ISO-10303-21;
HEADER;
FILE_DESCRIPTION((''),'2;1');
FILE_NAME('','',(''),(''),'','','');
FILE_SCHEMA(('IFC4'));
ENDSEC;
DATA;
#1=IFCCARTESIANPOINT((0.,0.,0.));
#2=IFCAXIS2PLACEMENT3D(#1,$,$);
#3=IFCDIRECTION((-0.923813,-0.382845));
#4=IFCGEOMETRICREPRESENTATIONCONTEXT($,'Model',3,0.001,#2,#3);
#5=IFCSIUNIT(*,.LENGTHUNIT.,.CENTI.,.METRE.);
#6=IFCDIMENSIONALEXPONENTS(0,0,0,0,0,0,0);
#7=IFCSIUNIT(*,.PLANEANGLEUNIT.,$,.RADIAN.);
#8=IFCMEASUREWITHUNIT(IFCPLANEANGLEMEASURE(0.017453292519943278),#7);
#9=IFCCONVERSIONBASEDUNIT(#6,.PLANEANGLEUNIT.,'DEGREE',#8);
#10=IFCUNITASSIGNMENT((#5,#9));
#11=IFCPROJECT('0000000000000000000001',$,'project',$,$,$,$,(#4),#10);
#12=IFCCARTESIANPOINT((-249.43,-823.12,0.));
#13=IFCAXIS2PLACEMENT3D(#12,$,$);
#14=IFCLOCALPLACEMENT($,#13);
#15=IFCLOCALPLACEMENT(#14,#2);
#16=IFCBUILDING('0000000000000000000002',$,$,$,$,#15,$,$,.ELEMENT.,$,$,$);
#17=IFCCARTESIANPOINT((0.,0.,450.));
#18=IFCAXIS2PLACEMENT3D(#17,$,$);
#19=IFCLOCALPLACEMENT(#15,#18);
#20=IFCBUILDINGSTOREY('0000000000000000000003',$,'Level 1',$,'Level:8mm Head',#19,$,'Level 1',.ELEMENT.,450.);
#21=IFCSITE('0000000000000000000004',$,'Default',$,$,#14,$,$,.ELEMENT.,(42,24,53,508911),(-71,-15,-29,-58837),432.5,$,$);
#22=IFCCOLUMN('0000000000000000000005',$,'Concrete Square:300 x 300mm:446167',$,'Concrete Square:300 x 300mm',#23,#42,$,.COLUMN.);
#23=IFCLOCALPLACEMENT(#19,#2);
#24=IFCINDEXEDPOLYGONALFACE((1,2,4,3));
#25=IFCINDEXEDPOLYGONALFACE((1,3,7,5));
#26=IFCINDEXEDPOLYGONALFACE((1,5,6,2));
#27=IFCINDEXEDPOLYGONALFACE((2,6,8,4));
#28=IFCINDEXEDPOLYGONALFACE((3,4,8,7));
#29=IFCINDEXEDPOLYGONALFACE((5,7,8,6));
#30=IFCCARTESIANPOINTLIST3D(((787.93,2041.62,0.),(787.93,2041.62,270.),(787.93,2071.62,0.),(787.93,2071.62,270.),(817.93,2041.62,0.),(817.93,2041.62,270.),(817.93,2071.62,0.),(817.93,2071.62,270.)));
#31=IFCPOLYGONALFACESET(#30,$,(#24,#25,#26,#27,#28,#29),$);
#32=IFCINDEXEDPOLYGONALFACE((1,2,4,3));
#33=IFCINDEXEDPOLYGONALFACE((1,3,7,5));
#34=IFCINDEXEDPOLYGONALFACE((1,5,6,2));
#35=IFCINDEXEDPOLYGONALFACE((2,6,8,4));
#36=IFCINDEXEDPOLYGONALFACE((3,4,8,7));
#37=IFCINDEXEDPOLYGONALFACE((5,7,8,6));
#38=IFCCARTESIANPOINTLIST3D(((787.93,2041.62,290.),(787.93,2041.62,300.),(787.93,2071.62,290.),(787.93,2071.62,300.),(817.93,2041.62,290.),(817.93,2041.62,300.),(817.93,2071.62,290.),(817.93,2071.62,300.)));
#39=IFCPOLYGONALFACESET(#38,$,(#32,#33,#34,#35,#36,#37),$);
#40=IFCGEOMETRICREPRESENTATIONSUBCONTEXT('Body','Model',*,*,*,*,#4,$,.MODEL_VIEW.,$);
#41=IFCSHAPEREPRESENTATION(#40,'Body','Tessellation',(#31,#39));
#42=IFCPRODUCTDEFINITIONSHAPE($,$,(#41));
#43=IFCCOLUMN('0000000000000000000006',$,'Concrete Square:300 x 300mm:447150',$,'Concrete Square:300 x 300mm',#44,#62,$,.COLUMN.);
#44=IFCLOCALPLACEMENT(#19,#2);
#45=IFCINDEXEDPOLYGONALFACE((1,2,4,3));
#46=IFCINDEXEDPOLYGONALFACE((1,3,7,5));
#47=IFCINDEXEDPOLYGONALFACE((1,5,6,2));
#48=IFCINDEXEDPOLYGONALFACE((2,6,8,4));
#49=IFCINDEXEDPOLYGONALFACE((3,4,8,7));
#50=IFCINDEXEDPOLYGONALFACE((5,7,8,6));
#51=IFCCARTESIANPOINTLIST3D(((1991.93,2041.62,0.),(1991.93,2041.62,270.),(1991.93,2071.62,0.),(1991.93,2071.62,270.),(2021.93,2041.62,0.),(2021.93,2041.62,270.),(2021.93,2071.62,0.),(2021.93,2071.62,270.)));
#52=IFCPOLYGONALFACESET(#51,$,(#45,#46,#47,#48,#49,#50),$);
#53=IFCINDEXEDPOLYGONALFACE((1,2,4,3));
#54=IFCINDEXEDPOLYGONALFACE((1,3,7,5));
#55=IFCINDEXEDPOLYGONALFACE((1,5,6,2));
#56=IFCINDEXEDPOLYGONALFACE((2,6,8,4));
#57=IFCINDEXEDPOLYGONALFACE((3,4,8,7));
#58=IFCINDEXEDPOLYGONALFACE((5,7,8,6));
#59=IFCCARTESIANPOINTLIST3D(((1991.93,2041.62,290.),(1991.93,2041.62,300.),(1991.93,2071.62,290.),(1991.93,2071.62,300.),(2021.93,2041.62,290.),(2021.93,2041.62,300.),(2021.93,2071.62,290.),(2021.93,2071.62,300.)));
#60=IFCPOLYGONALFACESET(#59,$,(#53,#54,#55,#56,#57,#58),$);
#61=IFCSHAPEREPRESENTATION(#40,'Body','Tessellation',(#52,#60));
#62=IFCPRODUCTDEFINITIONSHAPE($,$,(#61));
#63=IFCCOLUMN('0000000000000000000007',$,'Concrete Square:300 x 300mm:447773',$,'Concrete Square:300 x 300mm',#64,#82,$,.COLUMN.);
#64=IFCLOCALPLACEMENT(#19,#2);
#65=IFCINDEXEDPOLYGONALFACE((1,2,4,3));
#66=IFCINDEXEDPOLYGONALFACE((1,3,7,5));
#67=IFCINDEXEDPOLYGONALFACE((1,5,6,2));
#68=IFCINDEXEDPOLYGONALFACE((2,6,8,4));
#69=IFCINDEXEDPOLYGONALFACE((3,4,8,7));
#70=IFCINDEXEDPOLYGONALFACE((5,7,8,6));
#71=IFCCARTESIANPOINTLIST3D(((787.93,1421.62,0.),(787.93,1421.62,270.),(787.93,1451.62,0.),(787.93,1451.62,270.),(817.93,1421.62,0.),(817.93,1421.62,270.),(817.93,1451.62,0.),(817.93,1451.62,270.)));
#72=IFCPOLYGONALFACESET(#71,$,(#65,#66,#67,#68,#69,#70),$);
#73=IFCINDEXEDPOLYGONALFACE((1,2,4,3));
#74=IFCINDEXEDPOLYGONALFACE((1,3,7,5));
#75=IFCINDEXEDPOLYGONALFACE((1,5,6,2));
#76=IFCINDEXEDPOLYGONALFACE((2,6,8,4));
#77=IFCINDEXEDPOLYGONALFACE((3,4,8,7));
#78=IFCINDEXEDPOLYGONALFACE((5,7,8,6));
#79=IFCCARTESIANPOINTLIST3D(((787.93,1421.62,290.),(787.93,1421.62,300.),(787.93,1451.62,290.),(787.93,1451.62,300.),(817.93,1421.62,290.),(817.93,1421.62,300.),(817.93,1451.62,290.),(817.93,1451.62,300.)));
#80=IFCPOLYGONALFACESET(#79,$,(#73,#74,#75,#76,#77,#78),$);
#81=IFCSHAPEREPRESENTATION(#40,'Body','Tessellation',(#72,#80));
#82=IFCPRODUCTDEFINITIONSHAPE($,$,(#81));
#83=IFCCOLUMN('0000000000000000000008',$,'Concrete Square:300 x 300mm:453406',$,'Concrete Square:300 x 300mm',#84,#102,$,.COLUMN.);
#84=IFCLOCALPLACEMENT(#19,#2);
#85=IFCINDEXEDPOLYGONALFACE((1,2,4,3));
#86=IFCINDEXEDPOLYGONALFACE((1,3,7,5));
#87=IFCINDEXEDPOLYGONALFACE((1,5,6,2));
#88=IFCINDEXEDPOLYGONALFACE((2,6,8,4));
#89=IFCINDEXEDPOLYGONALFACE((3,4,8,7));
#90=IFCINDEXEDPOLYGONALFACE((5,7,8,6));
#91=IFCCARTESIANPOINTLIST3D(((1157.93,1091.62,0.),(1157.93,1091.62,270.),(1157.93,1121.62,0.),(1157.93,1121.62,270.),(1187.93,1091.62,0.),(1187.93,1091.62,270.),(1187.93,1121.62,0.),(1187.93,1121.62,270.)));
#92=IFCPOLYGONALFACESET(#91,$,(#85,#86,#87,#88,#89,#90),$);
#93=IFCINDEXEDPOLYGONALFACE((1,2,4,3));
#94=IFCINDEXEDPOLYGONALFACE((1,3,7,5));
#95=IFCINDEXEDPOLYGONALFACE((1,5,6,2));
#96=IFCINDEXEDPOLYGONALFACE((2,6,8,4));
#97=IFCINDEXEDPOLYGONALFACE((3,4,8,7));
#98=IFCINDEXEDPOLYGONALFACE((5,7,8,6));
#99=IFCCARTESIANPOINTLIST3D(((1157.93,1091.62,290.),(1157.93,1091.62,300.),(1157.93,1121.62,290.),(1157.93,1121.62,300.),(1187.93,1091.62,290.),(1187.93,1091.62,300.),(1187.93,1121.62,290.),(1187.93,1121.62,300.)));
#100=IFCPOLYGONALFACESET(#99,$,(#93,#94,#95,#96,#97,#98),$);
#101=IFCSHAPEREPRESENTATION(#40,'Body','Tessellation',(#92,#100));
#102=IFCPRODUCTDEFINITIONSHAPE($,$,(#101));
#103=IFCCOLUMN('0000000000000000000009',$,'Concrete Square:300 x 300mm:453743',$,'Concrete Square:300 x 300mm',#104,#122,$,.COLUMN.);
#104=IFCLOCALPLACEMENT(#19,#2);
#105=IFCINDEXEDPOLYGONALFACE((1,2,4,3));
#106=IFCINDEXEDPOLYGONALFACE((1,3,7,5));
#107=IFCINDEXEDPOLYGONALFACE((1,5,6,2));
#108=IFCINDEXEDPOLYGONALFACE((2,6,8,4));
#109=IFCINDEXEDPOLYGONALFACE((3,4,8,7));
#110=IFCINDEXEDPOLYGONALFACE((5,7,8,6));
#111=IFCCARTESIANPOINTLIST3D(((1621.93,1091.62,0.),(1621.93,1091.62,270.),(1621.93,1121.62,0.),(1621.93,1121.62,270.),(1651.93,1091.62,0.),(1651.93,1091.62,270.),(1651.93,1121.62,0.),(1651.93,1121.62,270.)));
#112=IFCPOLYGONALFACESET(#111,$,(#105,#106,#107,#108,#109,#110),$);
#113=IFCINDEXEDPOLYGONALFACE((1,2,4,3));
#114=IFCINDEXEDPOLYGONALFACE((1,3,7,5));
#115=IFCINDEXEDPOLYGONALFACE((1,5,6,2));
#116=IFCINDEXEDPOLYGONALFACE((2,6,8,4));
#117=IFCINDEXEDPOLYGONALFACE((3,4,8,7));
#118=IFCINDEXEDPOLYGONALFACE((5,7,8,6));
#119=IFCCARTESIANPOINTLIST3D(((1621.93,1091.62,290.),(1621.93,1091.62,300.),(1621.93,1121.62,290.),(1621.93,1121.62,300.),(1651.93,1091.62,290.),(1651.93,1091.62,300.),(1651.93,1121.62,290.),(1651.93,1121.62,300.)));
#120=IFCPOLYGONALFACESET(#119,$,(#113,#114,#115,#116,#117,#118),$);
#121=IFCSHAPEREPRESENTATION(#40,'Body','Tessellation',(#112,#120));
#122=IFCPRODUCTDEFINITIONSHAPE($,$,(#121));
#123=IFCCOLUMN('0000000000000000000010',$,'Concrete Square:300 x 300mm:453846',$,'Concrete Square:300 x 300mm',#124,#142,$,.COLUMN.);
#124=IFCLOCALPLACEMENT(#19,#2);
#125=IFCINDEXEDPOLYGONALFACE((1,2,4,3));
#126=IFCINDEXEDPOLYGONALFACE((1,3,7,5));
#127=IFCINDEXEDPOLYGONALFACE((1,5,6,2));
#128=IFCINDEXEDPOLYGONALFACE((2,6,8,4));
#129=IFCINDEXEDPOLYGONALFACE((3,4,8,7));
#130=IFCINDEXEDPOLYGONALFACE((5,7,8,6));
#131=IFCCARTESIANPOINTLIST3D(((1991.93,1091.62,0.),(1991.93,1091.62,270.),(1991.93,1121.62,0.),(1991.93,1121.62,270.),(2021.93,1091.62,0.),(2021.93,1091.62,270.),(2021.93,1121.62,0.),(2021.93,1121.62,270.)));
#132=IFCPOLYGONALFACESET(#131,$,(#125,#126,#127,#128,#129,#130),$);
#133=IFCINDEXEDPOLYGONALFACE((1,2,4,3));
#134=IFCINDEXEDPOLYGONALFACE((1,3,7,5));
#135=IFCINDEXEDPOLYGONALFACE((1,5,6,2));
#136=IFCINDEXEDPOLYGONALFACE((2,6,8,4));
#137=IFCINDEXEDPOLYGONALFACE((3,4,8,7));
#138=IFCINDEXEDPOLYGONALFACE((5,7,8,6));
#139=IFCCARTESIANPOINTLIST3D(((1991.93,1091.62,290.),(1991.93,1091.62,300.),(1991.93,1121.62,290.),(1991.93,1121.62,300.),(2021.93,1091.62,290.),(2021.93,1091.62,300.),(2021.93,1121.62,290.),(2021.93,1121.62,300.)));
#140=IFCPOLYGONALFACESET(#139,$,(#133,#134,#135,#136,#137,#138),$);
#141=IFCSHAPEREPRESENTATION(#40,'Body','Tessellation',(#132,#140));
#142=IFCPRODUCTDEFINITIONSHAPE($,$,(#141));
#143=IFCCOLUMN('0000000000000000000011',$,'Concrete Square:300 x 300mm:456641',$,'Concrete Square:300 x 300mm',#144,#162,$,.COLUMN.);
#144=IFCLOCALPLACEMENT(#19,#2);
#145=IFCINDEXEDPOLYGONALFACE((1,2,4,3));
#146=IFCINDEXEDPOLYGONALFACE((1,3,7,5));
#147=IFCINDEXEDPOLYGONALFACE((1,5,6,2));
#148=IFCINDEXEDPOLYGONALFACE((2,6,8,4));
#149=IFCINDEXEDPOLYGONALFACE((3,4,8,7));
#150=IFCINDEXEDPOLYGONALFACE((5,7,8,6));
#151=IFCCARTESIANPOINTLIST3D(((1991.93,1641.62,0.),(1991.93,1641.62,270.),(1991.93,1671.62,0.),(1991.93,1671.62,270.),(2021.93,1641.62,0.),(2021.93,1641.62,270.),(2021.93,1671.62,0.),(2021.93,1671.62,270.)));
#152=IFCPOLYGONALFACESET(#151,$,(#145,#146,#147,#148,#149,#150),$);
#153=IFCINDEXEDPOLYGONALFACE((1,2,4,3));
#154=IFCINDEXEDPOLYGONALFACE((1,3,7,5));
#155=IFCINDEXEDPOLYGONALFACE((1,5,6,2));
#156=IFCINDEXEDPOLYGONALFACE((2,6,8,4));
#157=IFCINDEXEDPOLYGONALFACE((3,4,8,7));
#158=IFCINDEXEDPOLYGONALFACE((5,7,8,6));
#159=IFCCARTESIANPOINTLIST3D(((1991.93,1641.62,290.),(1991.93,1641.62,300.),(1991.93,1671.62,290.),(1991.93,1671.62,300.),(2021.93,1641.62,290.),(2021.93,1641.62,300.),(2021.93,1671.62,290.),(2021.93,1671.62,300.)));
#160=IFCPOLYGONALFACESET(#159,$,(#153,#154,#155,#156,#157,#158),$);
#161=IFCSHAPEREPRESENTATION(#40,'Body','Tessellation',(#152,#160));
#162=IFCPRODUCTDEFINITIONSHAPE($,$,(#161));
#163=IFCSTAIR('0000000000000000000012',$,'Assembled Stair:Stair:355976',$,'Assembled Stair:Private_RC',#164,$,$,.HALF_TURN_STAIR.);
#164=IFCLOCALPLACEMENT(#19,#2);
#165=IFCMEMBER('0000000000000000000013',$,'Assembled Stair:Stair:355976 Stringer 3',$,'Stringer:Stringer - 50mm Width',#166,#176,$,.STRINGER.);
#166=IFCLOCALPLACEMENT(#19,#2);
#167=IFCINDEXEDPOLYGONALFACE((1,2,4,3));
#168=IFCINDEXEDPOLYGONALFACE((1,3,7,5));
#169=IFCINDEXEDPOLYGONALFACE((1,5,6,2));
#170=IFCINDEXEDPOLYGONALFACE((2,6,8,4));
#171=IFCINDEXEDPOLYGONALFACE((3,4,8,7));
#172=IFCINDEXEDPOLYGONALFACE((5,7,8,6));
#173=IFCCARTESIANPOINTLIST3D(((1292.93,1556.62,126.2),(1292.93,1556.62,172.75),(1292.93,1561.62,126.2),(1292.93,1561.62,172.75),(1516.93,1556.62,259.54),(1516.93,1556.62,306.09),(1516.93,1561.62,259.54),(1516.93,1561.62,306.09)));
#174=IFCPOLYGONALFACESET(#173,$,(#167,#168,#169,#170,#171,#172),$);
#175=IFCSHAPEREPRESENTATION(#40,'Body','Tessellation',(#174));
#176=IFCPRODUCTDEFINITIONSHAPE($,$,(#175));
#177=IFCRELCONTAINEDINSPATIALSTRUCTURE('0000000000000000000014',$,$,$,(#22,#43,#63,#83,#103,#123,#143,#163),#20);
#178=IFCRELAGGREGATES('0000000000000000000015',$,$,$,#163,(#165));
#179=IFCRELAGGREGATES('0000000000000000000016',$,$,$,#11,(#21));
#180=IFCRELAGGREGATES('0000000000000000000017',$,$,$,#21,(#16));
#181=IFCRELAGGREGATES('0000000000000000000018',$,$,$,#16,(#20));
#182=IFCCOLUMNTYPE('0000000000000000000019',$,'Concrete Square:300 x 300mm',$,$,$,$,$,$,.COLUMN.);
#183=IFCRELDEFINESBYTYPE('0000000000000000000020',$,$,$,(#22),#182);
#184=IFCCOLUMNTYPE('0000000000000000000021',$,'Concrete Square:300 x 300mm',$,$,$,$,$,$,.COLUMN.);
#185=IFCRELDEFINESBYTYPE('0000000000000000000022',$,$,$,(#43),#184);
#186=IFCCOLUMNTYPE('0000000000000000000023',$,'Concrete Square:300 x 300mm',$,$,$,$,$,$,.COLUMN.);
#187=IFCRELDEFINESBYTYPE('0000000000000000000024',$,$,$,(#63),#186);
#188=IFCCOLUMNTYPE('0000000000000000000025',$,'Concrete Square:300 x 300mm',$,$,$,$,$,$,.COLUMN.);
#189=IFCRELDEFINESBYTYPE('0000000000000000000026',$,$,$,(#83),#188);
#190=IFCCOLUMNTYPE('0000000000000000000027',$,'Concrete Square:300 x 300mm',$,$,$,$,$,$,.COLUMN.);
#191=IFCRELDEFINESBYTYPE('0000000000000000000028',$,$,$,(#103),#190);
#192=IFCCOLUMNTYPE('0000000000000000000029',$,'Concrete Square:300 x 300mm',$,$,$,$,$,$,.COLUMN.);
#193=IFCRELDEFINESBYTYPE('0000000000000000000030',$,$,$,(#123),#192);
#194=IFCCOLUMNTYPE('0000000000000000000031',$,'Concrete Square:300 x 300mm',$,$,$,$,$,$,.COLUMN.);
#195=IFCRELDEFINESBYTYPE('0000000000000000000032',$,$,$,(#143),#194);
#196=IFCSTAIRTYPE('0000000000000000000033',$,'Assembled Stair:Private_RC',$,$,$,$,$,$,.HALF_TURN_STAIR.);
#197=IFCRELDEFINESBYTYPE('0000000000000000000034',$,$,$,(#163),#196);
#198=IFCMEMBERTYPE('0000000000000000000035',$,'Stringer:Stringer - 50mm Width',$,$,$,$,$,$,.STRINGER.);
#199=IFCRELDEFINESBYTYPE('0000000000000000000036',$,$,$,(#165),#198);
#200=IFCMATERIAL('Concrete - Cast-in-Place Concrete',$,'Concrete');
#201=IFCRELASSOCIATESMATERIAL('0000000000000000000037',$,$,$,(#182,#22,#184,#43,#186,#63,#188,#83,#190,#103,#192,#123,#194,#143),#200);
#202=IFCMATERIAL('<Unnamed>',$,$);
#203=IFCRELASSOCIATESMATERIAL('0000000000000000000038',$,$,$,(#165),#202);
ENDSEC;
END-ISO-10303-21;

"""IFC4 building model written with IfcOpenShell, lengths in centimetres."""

from ifc_helpers import new_model, entity, si_unit, converted_unit, direction, frame, origin, place, context, subcontext, project, spatial, indexed_curve, outline, extrude, source, transform, mapped, material, type_object, type_shapes, element, aggregate, save


model = new_model("IFC4")

# Units and contexts
model_context = context("Model", 3, precision=0.001, world=origin(), true_north=direction((-0.923813, -0.382845)))
body_context = subcontext(model_context, "Body", "Model", "MODEL_VIEW")
ifc_project = project(units=[si_unit("LENGTHUNIT", "METRE", prefix="CENTI"), converted_unit("PLANEANGLEUNIT", "DEGREE", entity("IfcPlaneAngleMeasure", 0.017453292519943278), si_unit("PLANEANGLEUNIT", "RADIAN"), dimensions=[0, 0, 0, 0, 0, 0, 0])], contexts=[model_context])

# Site, building, storey
site_placement = place(None, frame((-249.43, -823.12, 0.0)))
site = spatial("IfcSite", under=ifc_project, at=site_placement, Name="Default", CompositionType="ELEMENT", RefLatitude=(42, 24, 53, 508911), RefLongitude=(-71, -15, -29, -58837), RefElevation=432.5)
building_placement = place(site_placement, origin())
building = spatial("IfcBuilding", under=site, at=building_placement, CompositionType="ELEMENT")
storey_placement = place(building_placement, frame((0.0, 0.0, 450.0)))
storey = spatial("IfcBuildingStorey", under=building, at=storey_placement, Name="Level 1", ObjectType="Level:8mm Head", LongName="Level 1", CompositionType="ELEMENT", Elevation=450.0)

# Columns
ifc_material_1 = material(Name="Concrete - Cast-in-Place Concrete", Category="Concrete")
column_type_1 = type_object("IfcColumnType", Name="Concrete Square:300 x 300mm", PredefinedType="COLUMN", material=ifc_material_1)
shared_shape_1 = source(origin(), body_context, "Body", "SweptSolid", [
    extrude(outline(indexed_curve([(-15.0, -15.0), (15.0, -15.0), (15.0, 15.0), (-15.0, 15.0), (-15.0, -15.0)], self_intersect=False)), frame((802.93, 2056.62, 450.0), z_axis=(0.0, 0.0, 1.0), x_axis=(-1.0, 0.0, 0.0)), (0.0, 0.0, 1.0), 270.0),
    extrude(outline(indexed_curve([(-15.0, -15.0), (15.0, -15.0), (15.0, 15.0), (-15.0, 15.0), (-15.0, -15.0)], self_intersect=False)), frame((802.93, 2056.62, 740.0), z_axis=(0.0, 0.0, 1.0), x_axis=(-1.0, 0.0, 0.0)), (0.0, 0.0, 1.0), 10.0),
])
type_shapes(column_type_1, [shared_shape_1])
column_1_placement = place(storey_placement, frame((0.0, 0.0, -450.0)))
element("IfcColumn", 1, at=column_1_placement, inside=storey, type_object=column_type_1, material=ifc_material_1, Name="Concrete Square:300 x 300mm:446167", ObjectType="Concrete Square:300 x 300mm", PredefinedType="COLUMN", context=body_context, shape_type="MappedRepresentation", body=[
    mapped(shared_shape_1, transform((0.0, 0.0, 0.0), scale=1.0)),
])
column_type_2 = type_object("IfcColumnType", Name="Concrete Square:300 x 300mm", PredefinedType="COLUMN", material=ifc_material_1)
shared_shape_2 = source(origin(), body_context, "Body", "SweptSolid", [
    extrude(outline(indexed_curve([(-15.0, -15.0), (15.0, -15.0), (15.0, 15.0), (-15.0, 15.0), (-15.0, -15.0)], self_intersect=False)), frame((2006.93, 2056.62, 450.0), z_axis=(0.0, 0.0, 1.0), x_axis=(-1.0, 0.0, 0.0)), (0.0, 0.0, 1.0), 270.0),
    extrude(outline(indexed_curve([(-15.0, -15.0), (15.0, -15.0), (15.0, 15.0), (-15.0, 15.0), (-15.0, -15.0)], self_intersect=False)), frame((2006.93, 2056.62, 740.0), z_axis=(0.0, 0.0, 1.0), x_axis=(-1.0, 0.0, 0.0)), (0.0, 0.0, 1.0), 10.0),
])
type_shapes(column_type_2, [shared_shape_2])
column_2_placement = place(storey_placement, frame((0.0, 0.0, -450.0)))
element("IfcColumn", 2, at=column_2_placement, inside=storey, type_object=column_type_2, material=ifc_material_1, Name="Concrete Square:300 x 300mm:447150", ObjectType="Concrete Square:300 x 300mm", PredefinedType="COLUMN", context=body_context, shape_type="MappedRepresentation", body=[
    mapped(shared_shape_2, transform((0.0, 0.0, 0.0), scale=1.0)),
])
column_type_3 = type_object("IfcColumnType", Name="Concrete Square:300 x 300mm", PredefinedType="COLUMN", material=ifc_material_1)
shared_shape_3 = source(origin(), body_context, "Body", "SweptSolid", [
    extrude(outline(indexed_curve([(-15.0, -15.0), (15.0, -15.0), (15.0, 15.0), (-15.0, 15.0), (-15.0, -15.0)], self_intersect=False)), frame((802.93, 1436.62, 450.0), z_axis=(0.0, 0.0, 1.0), x_axis=(-1.0, 0.0, 0.0)), (0.0, 0.0, 1.0), 270.0),
    extrude(outline(indexed_curve([(-15.0, -15.0), (15.0, -15.0), (15.0, 15.0), (-15.0, 15.0), (-15.0, -15.0)], self_intersect=False)), frame((802.93, 1436.62, 740.0), z_axis=(0.0, 0.0, 1.0), x_axis=(-1.0, 0.0, 0.0)), (0.0, 0.0, 1.0), 10.0),
])
type_shapes(column_type_3, [shared_shape_3])
column_3_placement = place(storey_placement, frame((0.0, 0.0, -450.0)))
element("IfcColumn", 3, at=column_3_placement, inside=storey, type_object=column_type_3, material=ifc_material_1, Name="Concrete Square:300 x 300mm:447773", ObjectType="Concrete Square:300 x 300mm", PredefinedType="COLUMN", context=body_context, shape_type="MappedRepresentation", body=[
    mapped(shared_shape_3, transform((0.0, 0.0, 0.0), scale=1.0)),
])
column_type_4 = type_object("IfcColumnType", Name="Concrete Square:300 x 300mm", PredefinedType="COLUMN", material=ifc_material_1)
shared_shape_4 = source(origin(), body_context, "Body", "SweptSolid", [
    extrude(outline(indexed_curve([(-15.0, -15.0), (15.0, -15.0), (15.0, 15.0), (-15.0, 15.0), (-15.0, -15.0)], self_intersect=False)), frame((1172.93, 1106.62, 450.0), z_axis=(0.0, 0.0, 1.0), x_axis=(-1.0, 0.0, 0.0)), (0.0, 0.0, 1.0), 270.0),
    extrude(outline(indexed_curve([(-15.0, -15.0), (15.0, -15.0), (15.0, 15.0), (-15.0, 15.0), (-15.0, -15.0)], self_intersect=False)), frame((1172.93, 1106.62, 740.0), z_axis=(0.0, 0.0, 1.0), x_axis=(-1.0, 0.0, 0.0)), (0.0, 0.0, 1.0), 10.0),
])
type_shapes(column_type_4, [shared_shape_4])
column_4_placement = place(storey_placement, frame((0.0, 0.0, -450.0)))
element("IfcColumn", 4, at=column_4_placement, inside=storey, type_object=column_type_4, material=ifc_material_1, Name="Concrete Square:300 x 300mm:453406", ObjectType="Concrete Square:300 x 300mm", PredefinedType="COLUMN", context=body_context, shape_type="MappedRepresentation", body=[
    mapped(shared_shape_4, transform((0.0, 0.0, 0.0), scale=1.0)),
])
column_type_5 = type_object("IfcColumnType", Name="Concrete Square:300 x 300mm", PredefinedType="COLUMN", material=ifc_material_1)
shared_shape_5 = source(origin(), body_context, "Body", "SweptSolid", [
    extrude(outline(indexed_curve([(-15.0, -15.0), (15.0, -15.0), (15.0, 15.0), (-15.0, 15.0), (-15.0, -15.0)], self_intersect=False)), frame((1636.93, 1106.62, 450.0), z_axis=(0.0, 0.0, 1.0), x_axis=(-1.0, 0.0, 0.0)), (0.0, 0.0, 1.0), 270.0),
    extrude(outline(indexed_curve([(-15.0, -15.0), (15.0, -15.0), (15.0, 15.0), (-15.0, 15.0), (-15.0, -15.0)], self_intersect=False)), frame((1636.93, 1106.62, 740.0), z_axis=(0.0, 0.0, 1.0), x_axis=(-1.0, 0.0, 0.0)), (0.0, 0.0, 1.0), 10.0),
])
type_shapes(column_type_5, [shared_shape_5])
column_5_placement = place(storey_placement, frame((0.0, 0.0, -450.0)))
element("IfcColumn", 5, at=column_5_placement, inside=storey, type_object=column_type_5, material=ifc_material_1, Name="Concrete Square:300 x 300mm:453743", ObjectType="Concrete Square:300 x 300mm", PredefinedType="COLUMN", context=body_context, shape_type="MappedRepresentation", body=[
    mapped(shared_shape_5, transform((0.0, 0.0, 0.0), scale=1.0)),
])
column_type_6 = type_object("IfcColumnType", Name="Concrete Square:300 x 300mm", PredefinedType="COLUMN", material=ifc_material_1)
shared_shape_6 = source(origin(), body_context, "Body", "SweptSolid", [
    extrude(outline(indexed_curve([(-15.0, -15.0), (15.0, -15.0), (15.0, 15.0), (-15.0, 15.0), (-15.0, -15.0)], self_intersect=False)), frame((2006.93, 1106.62, 450.0), z_axis=(0.0, 0.0, 1.0), x_axis=(-1.0, 0.0, 0.0)), (0.0, 0.0, 1.0), 270.0),
    extrude(outline(indexed_curve([(-15.0, -15.0), (15.0, -15.0), (15.0, 15.0), (-15.0, 15.0), (-15.0, -15.0)], self_intersect=False)), frame((2006.93, 1106.62, 740.0), z_axis=(0.0, 0.0, 1.0), x_axis=(-1.0, 0.0, 0.0)), (0.0, 0.0, 1.0), 10.0),
])
type_shapes(column_type_6, [shared_shape_6])
column_6_placement = place(storey_placement, frame((0.0, 0.0, -450.0)))
element("IfcColumn", 6, at=column_6_placement, inside=storey, type_object=column_type_6, material=ifc_material_1, Name="Concrete Square:300 x 300mm:453846", ObjectType="Concrete Square:300 x 300mm", PredefinedType="COLUMN", context=body_context, shape_type="MappedRepresentation", body=[
    mapped(shared_shape_6, transform((0.0, 0.0, 0.0), scale=1.0)),
])
column_type_7 = type_object("IfcColumnType", Name="Concrete Square:300 x 300mm", PredefinedType="COLUMN", material=ifc_material_1)
shared_shape_7 = source(origin(), body_context, "Body", "SweptSolid", [
    extrude(outline(indexed_curve([(-15.0, -15.0), (15.0, -15.0), (15.0, 15.0), (-15.0, 15.0), (-15.0, -15.0)], self_intersect=False)), frame((2006.93, 1656.62, 450.0), z_axis=(0.0, 0.0, 1.0), x_axis=(-1.0, 0.0, 0.0)), (0.0, 0.0, 1.0), 270.0),
    extrude(outline(indexed_curve([(-15.0, -15.0), (15.0, -15.0), (15.0, 15.0), (-15.0, 15.0), (-15.0, -15.0)], self_intersect=False)), frame((2006.93, 1656.62, 740.0), z_axis=(0.0, 0.0, 1.0), x_axis=(-1.0, 0.0, 0.0)), (0.0, 0.0, 1.0), 10.0),
])
type_shapes(column_type_7, [shared_shape_7])
column_7_placement = place(storey_placement, frame((0.0, 0.0, -450.0)))
element("IfcColumn", 7, at=column_7_placement, inside=storey, type_object=column_type_7, material=ifc_material_1, Name="Concrete Square:300 x 300mm:456641", ObjectType="Concrete Square:300 x 300mm", PredefinedType="COLUMN", context=body_context, shape_type="MappedRepresentation", body=[
    mapped(shared_shape_7, transform((0.0, 0.0, 0.0), scale=1.0)),
])

# Stair, member
stair_type = type_object("IfcStairType", Name="Assembled Stair:Private_RC", PredefinedType="HALF_TURN_STAIR")
stair_placement = place(storey_placement, origin())
stair = element("IfcStair", 8, at=stair_placement, inside=storey, type_object=stair_type, Name="Assembled Stair:Stair:355976", ObjectType="Assembled Stair:Private_RC", PredefinedType="HALF_TURN_STAIR")
ifc_material_2 = material(Name="<Unnamed>")
member_type_1 = type_object("IfcMemberType", Name="Stringer:Stringer - 50mm Width", PredefinedType="STRINGER")
member_1_placement = place(stair_placement, origin())
member_1 = element("IfcMember", 9, at=member_1_placement, type_object=member_type_1, material=ifc_material_2, Name="Assembled Stair:Stair:355976 Stringer 3", ObjectType="Stringer:Stringer - 50mm Width", PredefinedType="STRINGER", context=body_context, shape_type="SweptSolid", body=[
    extrude(outline(indexed_curve([(-118.43, -20.0), (142.24, -20.0), (118.43, 20.0), (-142.24, 20.0), (-118.43, -20.0)], self_intersect=False)), frame((1404.93, 1556.62, 216.15), z_axis=(0.0, 1.0, 0.0), x_axis=(0.859293, 0.0, 0.511484)), (0.0, 0.0, 1.0), 5.0),
])

aggregate(stair, [member_1])

save(model, "model.ifc")
